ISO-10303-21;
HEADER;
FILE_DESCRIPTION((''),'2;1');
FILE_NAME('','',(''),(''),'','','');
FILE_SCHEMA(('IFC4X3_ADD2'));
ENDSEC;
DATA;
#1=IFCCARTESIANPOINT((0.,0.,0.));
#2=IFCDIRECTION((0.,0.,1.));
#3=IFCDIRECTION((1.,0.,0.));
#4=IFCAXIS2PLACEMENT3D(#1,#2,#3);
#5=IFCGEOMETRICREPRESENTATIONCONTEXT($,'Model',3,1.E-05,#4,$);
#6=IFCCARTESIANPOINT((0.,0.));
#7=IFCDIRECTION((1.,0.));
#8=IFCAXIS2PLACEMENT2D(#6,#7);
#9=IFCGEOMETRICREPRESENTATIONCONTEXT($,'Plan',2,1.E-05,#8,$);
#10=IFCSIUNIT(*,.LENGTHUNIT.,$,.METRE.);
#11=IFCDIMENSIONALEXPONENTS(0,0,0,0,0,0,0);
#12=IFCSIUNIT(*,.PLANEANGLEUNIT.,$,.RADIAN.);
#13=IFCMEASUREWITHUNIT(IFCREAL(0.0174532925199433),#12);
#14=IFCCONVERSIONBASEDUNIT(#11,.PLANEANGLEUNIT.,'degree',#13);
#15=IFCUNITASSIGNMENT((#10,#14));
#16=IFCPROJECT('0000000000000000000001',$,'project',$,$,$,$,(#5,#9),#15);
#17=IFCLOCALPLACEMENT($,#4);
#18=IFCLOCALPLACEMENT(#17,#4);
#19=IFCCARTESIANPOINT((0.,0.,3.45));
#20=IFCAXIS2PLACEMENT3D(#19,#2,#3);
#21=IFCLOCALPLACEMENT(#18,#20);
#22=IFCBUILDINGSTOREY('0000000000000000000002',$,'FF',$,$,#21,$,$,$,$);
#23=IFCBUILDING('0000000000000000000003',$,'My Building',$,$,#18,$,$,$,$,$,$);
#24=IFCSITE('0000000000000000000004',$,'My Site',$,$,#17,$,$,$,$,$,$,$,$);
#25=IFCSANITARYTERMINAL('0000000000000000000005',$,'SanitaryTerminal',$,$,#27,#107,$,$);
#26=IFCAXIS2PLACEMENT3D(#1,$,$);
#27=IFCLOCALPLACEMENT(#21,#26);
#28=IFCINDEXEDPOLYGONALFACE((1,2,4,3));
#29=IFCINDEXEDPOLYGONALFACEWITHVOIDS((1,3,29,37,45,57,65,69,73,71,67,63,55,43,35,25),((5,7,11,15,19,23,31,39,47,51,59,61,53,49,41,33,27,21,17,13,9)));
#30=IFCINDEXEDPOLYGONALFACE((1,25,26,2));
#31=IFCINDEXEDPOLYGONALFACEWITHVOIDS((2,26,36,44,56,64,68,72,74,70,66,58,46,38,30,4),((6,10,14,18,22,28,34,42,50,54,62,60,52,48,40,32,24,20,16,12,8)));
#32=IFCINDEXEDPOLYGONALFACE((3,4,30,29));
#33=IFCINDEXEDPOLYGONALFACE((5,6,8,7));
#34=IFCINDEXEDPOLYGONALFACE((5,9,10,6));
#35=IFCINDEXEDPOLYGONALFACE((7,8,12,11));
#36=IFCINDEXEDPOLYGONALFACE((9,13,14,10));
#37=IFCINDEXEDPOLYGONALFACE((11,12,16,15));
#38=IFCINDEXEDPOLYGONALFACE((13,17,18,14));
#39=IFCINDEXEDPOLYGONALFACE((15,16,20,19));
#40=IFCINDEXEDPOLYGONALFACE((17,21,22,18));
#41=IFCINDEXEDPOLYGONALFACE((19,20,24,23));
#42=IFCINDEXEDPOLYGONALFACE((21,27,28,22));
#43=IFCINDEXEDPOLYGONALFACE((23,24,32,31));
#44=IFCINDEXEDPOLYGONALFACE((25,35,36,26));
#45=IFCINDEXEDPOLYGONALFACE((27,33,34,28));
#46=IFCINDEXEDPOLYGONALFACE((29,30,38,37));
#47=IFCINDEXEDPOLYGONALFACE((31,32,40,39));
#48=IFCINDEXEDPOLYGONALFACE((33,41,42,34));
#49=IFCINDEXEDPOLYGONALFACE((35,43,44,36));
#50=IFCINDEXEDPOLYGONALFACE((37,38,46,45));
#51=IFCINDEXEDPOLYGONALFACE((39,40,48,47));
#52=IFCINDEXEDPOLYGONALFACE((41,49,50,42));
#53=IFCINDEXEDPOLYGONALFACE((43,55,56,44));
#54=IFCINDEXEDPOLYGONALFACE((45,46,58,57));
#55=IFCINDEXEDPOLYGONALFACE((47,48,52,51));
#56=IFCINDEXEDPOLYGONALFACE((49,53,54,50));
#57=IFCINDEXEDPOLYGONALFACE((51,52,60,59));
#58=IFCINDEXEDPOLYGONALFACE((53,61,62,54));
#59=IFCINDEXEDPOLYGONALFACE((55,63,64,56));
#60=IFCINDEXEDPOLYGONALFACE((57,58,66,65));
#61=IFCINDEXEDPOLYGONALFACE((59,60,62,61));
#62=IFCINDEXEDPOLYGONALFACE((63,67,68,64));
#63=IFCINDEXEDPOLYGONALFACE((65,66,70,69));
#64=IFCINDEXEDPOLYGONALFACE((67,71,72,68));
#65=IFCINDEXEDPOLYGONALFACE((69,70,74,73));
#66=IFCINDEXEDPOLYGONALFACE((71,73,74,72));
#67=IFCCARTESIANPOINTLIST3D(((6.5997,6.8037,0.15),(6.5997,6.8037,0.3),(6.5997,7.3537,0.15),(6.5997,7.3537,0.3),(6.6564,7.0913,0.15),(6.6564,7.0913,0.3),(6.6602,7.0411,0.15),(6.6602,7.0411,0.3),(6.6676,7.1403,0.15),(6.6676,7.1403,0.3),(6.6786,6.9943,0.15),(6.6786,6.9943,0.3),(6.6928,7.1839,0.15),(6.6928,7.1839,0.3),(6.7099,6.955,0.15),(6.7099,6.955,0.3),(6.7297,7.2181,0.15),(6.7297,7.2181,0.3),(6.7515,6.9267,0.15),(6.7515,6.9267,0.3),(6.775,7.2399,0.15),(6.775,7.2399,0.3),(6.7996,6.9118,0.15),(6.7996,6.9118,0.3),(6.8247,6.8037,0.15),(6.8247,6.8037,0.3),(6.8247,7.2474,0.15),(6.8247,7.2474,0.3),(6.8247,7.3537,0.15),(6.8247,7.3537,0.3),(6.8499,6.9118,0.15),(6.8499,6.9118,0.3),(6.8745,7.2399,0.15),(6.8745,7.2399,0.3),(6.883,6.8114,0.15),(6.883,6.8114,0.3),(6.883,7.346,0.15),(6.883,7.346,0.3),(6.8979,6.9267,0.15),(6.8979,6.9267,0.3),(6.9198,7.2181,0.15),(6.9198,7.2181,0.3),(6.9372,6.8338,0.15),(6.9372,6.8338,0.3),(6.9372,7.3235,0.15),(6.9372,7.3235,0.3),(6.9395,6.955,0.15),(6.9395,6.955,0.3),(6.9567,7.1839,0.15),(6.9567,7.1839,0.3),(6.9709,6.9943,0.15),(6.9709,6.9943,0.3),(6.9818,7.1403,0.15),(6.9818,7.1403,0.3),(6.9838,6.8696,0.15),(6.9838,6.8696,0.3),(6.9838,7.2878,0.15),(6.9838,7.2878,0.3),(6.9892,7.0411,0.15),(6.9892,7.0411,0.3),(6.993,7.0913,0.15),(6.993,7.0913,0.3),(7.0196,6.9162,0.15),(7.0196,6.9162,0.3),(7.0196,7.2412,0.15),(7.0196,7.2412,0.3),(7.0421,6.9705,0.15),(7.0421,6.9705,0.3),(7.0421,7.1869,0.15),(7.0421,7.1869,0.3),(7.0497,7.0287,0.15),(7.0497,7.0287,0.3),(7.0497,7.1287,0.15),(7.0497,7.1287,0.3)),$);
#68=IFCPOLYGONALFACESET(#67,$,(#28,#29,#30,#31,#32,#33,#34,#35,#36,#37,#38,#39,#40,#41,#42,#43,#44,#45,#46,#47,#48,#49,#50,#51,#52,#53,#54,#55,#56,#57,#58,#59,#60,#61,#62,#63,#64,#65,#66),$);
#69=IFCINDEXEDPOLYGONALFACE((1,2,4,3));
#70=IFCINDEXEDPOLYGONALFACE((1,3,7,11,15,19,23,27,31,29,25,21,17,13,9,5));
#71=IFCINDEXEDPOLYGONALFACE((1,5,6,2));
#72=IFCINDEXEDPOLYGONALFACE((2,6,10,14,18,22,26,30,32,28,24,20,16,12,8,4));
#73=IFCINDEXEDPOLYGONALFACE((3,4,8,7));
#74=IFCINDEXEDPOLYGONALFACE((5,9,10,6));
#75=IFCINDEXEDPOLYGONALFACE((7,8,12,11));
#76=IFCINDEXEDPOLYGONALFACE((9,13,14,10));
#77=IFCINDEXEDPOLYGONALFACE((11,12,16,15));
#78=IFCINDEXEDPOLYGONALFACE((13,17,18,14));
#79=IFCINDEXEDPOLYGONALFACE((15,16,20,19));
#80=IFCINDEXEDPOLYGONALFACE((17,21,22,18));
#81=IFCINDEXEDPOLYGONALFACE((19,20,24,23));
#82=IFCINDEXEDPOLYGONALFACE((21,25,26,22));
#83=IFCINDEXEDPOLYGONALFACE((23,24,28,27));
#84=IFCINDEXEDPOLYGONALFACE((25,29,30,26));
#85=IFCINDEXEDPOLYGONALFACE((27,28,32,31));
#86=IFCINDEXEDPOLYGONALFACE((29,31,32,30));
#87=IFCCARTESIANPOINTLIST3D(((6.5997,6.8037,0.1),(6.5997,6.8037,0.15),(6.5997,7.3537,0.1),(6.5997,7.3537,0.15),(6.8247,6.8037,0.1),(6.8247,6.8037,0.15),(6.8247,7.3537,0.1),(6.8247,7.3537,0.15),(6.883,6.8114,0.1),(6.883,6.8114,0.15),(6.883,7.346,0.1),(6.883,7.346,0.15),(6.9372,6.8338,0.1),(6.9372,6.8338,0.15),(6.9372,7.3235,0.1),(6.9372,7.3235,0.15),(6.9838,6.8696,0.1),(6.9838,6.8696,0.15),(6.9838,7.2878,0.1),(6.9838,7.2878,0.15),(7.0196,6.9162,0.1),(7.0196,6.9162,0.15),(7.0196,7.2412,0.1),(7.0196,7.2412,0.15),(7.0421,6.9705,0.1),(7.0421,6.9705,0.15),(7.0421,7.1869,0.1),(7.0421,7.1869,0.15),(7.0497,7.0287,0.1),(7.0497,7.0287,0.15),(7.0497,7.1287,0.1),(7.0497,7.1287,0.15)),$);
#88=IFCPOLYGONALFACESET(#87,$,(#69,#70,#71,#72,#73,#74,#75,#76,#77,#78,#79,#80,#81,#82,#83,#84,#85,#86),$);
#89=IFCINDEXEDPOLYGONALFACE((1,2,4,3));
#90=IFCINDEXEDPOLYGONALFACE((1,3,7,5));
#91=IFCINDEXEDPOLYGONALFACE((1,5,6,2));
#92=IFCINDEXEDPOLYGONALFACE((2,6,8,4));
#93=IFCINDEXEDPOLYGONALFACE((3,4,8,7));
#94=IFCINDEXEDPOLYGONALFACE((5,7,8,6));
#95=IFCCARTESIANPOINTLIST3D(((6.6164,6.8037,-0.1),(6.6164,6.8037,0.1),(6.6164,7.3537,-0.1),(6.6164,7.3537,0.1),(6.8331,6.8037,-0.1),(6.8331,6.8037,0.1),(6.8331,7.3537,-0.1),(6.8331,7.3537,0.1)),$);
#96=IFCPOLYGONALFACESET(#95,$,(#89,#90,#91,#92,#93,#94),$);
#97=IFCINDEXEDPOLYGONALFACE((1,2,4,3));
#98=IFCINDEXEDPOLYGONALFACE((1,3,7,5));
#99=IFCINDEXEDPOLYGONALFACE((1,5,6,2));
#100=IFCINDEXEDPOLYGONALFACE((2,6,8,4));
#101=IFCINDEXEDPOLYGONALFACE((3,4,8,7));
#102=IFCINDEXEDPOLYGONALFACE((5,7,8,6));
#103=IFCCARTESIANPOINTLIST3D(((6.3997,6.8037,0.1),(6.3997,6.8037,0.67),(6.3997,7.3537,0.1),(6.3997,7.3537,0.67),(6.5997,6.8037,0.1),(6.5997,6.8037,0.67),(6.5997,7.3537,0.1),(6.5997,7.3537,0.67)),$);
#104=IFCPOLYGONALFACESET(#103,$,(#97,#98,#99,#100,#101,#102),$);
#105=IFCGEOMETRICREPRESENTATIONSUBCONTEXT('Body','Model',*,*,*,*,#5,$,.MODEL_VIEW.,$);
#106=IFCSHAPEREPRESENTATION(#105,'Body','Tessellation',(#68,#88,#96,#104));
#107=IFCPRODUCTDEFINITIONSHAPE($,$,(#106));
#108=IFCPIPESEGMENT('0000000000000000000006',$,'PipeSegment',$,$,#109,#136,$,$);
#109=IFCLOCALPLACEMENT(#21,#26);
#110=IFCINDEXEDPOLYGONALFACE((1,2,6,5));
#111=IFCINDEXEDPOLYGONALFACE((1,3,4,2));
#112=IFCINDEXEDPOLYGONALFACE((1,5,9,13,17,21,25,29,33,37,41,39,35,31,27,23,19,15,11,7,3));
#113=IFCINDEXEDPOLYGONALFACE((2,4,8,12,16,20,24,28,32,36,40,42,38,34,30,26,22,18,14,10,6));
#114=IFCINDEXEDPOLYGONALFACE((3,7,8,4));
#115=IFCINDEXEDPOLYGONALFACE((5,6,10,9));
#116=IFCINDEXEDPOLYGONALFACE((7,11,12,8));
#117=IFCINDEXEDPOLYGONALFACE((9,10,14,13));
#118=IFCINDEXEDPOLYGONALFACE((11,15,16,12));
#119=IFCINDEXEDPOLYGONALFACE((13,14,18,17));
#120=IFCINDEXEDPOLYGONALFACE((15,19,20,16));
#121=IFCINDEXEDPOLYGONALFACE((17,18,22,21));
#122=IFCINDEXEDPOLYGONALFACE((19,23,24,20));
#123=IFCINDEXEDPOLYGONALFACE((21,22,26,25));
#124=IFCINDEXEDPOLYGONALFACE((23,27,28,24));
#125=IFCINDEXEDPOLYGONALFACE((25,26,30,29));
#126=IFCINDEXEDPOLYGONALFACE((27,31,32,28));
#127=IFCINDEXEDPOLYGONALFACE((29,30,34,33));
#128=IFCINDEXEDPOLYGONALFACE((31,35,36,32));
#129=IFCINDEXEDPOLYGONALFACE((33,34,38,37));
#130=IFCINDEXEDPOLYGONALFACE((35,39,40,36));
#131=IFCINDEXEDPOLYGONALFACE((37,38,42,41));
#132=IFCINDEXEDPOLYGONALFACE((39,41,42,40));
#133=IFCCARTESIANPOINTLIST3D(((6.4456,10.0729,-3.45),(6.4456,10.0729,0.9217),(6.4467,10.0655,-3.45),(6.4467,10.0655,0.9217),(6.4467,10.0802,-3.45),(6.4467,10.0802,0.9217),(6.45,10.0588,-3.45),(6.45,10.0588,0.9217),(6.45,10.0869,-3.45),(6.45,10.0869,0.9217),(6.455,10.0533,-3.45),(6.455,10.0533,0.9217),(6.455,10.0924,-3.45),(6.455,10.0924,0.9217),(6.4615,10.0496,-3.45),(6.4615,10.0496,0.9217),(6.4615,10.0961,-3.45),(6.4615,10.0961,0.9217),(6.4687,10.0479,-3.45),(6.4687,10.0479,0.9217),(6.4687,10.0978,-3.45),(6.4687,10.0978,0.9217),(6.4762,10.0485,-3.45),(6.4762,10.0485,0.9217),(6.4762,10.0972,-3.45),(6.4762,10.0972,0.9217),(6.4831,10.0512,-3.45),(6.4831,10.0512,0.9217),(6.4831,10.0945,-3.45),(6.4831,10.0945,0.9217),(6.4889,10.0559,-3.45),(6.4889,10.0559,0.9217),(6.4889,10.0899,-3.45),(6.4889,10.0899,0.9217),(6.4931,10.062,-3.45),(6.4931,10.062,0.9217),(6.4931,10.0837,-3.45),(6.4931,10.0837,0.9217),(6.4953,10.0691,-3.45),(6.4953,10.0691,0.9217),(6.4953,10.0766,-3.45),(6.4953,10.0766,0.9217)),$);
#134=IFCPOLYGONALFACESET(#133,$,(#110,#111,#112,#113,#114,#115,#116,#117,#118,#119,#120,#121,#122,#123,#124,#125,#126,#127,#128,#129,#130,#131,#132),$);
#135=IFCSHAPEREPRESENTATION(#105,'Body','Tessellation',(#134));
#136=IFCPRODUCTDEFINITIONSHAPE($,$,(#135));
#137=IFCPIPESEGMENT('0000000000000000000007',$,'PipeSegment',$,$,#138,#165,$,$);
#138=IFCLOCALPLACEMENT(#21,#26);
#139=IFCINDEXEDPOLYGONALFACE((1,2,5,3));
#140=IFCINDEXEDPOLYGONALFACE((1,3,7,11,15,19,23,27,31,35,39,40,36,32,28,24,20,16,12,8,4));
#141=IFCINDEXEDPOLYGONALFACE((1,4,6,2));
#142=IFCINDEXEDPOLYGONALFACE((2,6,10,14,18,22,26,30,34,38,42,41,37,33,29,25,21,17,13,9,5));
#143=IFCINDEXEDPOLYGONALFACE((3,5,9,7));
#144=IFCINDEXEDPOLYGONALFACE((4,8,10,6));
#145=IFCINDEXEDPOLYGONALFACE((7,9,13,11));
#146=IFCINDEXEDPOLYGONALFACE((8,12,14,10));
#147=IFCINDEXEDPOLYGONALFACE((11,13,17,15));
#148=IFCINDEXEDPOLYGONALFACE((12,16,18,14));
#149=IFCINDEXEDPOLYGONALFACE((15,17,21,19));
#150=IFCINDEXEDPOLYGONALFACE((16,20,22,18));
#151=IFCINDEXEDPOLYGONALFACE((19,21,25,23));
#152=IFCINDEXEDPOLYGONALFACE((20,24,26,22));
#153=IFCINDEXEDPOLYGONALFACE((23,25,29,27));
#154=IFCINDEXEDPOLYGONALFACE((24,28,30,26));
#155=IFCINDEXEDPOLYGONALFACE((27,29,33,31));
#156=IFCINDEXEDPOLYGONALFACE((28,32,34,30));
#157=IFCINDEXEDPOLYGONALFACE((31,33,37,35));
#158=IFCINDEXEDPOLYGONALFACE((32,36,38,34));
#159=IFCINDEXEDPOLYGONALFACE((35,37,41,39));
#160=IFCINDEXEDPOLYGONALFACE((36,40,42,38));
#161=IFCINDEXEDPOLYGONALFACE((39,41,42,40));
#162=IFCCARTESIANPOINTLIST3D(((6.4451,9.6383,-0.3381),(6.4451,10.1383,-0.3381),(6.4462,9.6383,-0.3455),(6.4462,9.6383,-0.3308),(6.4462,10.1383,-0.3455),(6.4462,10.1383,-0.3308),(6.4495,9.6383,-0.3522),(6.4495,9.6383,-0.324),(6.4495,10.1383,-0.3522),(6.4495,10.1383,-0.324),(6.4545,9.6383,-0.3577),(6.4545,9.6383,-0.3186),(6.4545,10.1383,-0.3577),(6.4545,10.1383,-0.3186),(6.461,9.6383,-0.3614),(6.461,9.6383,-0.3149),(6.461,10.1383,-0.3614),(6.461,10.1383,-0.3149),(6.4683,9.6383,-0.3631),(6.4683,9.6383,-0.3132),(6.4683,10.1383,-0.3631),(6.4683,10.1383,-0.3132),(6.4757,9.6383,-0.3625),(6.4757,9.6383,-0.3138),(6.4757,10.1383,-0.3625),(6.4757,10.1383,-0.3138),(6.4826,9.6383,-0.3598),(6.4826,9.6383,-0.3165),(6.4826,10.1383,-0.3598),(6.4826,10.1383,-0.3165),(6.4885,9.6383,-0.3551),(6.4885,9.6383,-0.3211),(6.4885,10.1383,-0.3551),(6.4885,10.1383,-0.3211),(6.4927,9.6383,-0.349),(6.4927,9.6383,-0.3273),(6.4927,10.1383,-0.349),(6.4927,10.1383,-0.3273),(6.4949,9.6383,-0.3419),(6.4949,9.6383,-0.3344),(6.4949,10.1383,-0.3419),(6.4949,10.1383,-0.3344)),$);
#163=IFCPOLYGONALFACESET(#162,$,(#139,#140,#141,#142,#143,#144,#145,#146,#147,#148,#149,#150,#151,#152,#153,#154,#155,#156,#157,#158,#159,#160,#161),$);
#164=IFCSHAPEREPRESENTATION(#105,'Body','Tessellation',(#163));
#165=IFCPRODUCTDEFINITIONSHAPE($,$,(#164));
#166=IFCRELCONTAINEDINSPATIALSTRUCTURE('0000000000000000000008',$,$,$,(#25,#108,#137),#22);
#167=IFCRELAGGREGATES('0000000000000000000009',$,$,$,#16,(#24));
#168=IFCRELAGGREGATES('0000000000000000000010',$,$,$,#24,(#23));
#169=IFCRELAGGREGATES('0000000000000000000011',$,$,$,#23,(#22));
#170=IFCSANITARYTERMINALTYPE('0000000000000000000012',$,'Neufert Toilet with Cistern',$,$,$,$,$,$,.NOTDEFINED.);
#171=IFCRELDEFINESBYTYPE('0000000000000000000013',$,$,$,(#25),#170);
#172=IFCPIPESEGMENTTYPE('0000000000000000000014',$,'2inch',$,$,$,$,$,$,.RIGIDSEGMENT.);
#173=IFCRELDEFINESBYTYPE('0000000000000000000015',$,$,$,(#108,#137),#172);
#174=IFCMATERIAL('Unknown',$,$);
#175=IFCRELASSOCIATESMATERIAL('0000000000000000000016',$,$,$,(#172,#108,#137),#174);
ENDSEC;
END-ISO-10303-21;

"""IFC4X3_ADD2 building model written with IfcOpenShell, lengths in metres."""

from ifc_helpers import new_model, entity, si_unit, converted_unit, frame, frame_2d, origin_with_axes, origin_2d_with_axis, place, context, subcontext, project, spatial, line, arc, indexed_curve, circle_curve, circle, outline, extrude, shape, source, transform, mapped, material, material_profile, profile_set, profile_usage, type_object, type_shapes, element, save


model = new_model("IFC4X3_ADD2")

# Units and contexts
model_context = context("Model", 3, precision=1e-05, world=origin_with_axes())
plan_context = context("Plan", 2, precision=1e-05, world=origin_2d_with_axis())
body_context_1 = subcontext(model_context, "Body", "Model", "MODEL_VIEW")
body_context_2 = subcontext(plan_context, "Body", "Plan", "PLAN_VIEW")
ifc_project = project(units=[si_unit("LENGTHUNIT", "METRE"), converted_unit("PLANEANGLEUNIT", "degree", entity("IfcReal", 0.0174532925199433), si_unit("PLANEANGLEUNIT", "RADIAN"), dimensions=[0, 0, 0, 0, 0, 0, 0])], contexts=[model_context, plan_context])

# Site, building, storey
site_placement = place(None, origin_with_axes())
site = spatial("IfcSite", under=ifc_project, at=site_placement, Name="My Site")
building_placement = place(site_placement, origin_with_axes())
building = spatial("IfcBuilding", under=site, at=building_placement, Name="My Building")
storey_placement = place(building_placement, frame((0.0, 0.0, 3.45), z_axis=(0.0, 0.0, 1.0), x_axis=(1.0, 0.0, 0.0)))
storey = spatial("IfcBuildingStorey", under=building, at=storey_placement, Name="FF")

# Shared definitions
ifc_material = material(Name="Unknown")

# Sanitary terminal
sanitary_terminal_type_1 = type_object("IfcSanitaryTerminalType", Name="Neufert Toilet with Cistern", PredefinedType="NOTDEFINED")
shared_shape_1 = source(origin_with_axes(), body_context_1, "Body", "SweptSolid", [
    extrude(outline(indexed_curve([(-0.275, -0.2), (0.275, -0.2), (0.275, -0.425), (0.2091, -0.5841), (0.05, -0.65), (-0.05, -0.65), (-0.2091, -0.5841), (-0.275, -0.425), (0.0, -0.5938), (0.0, -0.2563)], segments=[arc(8, 7, 6), line(6, 5), arc(5, 4, 3), line(3, 2), line(2, 1), line(1, 8)], self_intersect=False), holes=[circle_curve(frame_2d((0.0, -0.425)), 0.1687)]), frame((0.0, 0.0, 0.25), z_axis=(0.0, 0.0, 1.0), x_axis=(1.0, 0.0, 0.0)), (0.0, 0.0, 1.0), 0.15),
    extrude(outline(indexed_curve([(-0.275, -0.2), (0.275, -0.2), (0.275, -0.425), (0.2091, -0.5841), (0.05, -0.65), (-0.05, -0.65), (-0.2091, -0.5841), (-0.275, -0.425)], segments=[line(1, 2), line(2, 3), arc(3, 4, 5), line(5, 6), arc(6, 7, 8), line(8, 1)])), frame((0.0, 0.0, 0.2), z_axis=(0.0, 0.0, 1.0), x_axis=(1.0, 0.0, 0.0)), (0.0, 0.0, 1.0), 0.05),
    extrude(outline(indexed_curve([(-0.275, -0.2167), (0.275, -0.2167), (0.275, -0.4333), (-0.275, -0.4333)], segments=[line(1, 2, 3, 4, 1)])), origin_with_axes(), (0.0, 0.0, 1.0), 0.2),
    extrude(outline(indexed_curve([(-0.275, 0.0), (0.275, 0.0), (0.275, -0.2), (-0.275, -0.2)], segments=[line(1, 2, 3, 4, 1)])), frame((0.0, 0.0, 0.2), z_axis=(0.0, 0.0, 1.0), x_axis=(1.0, 0.0, 0.0)), (0.0, 0.0, 1.0), 0.57),
])
shared_shape_2 = source(origin_with_axes(), body_context_2, "Body", "Curve2D", [
    entity("IfcIndexedPolyCurve", entity("IfcCartesianPointList2D", [[-0.275, 0.0], [0.275, 0.0], [0.275, -0.2], [-0.275, -0.2]]), [entity("IfcLineIndex", [1, 2, 3, 4, 1])]),
    entity("IfcIndexedPolyCurve", entity("IfcCartesianPointList2D", [[0.165, -0.2], [0.1925, -0.335]])),
    entity("IfcTrimmedCurve", entity("IfcEllipse", entity("IfcAxis2Placement2D", entity("IfcCartesianPoint", [0.0, -0.335]), entity("IfcDirection", [1.0, 0.0])), 0.1925, 0.315), [entity("IfcCartesianPoint", [-0.1925, -0.335])], [entity("IfcCartesianPoint", [0.1925, -0.335])], True, "CARTESIAN"),
    entity("IfcIndexedPolyCurve", entity("IfcCartesianPointList2D", [[-0.165, -0.2], [-0.1925, -0.335]])),
    entity("IfcEllipse", entity("IfcAxis2Placement2D", entity("IfcCartesianPoint", [0.0, -0.452]), entity("IfcDirection", [1.0, 0.0])), 0.1313, 0.1575),
    entity("IfcIndexedPolyCurve", entity("IfcCartesianPointList2D", [[-0.0344, -0.452], [-0.0344, -0.4295], [0.0344, -0.4295], [0.0344, -0.452]])),
    entity("IfcTrimmedCurve", entity("IfcEllipse", entity("IfcAxis2Placement2D", entity("IfcCartesianPoint", [0.0, -0.452]), entity("IfcDirection", [1.0, 0.0])), 0.0344, 0.0225), [entity("IfcCartesianPoint", [-0.0344, -0.452])], [entity("IfcCartesianPoint", [0.0344, -0.452])], True, "CARTESIAN"),
])
type_shapes(sanitary_terminal_type_1, [shared_shape_1, shared_shape_2])
sanitary_terminal_1_placement = place(storey_placement, frame((6.3997, 7.0787, -0.1), z_axis=(0.0, 0.0, 1.0), x_axis=(0.0, 1.0, 0.0)))
element("IfcSanitaryTerminal", 1, at=sanitary_terminal_1_placement, inside=storey, type_object=sanitary_terminal_type_1, Name="SanitaryTerminal", shapes=[
    shape(body_context_1, "Body", "MappedRepresentation", [mapped(shared_shape_1, transform((0.0, 0.0, 0.0), x_axis=(1.0, 0.0, 0.0), y_axis=(0.0, 1.0, 0.0), z_axis=(0.0, 0.0, 1.0), scale=1.0))]),
    shape(body_context_2, "Body", "MappedRepresentation", [mapped(shared_shape_2, transform((0.0, 0.0, 0.0), x_axis=(1.0, 0.0, 0.0), y_axis=(0.0, 1.0, 0.0), z_axis=(0.0, 0.0, 1.0), scale=1.0))]),
])

# Pipe segments
ifc_material_profile = material_profile(ifc_material, circle(Radius=0.025))
ifc_profile_set = profile_set([ifc_material_profile])
ifc_profile_usage_1 = profile_usage(ifc_profile_set)
pipe_segment_type = type_object("IfcPipeSegmentType", Name="2inch", PredefinedType="RIGIDSEGMENT", material=ifc_profile_set)
pipe_segment_1_placement = place(storey_placement, frame((6.4706, 10.0729, -3.45), z_axis=(0.0, 0.0, 1.0), x_axis=(-1.0, 0.0, 0.0)))
element("IfcPipeSegment", 2, at=pipe_segment_1_placement, inside=storey, type_object=pipe_segment_type, material=ifc_profile_usage_1, Name="PipeSegment", context=body_context_1, shape_type="SweptSolid", body=[
    extrude(circle(Radius=0.025), origin_with_axes(), (0.0, 0.0, 1.0), 4.3717),
])
ifc_profile_usage_2 = profile_usage(ifc_profile_set)
pipe_segment_2_placement = place(storey_placement, frame((6.4701, 9.6383, -0.3381), z_axis=(0.0, 1.0, 0.0), x_axis=(-1.0, 0.0, 0.0)))
element("IfcPipeSegment", 3, at=pipe_segment_2_placement, inside=storey, type_object=pipe_segment_type, material=ifc_profile_usage_2, Name="PipeSegment", context=body_context_1, shape_type="SweptSolid", body=[
    extrude(circle(Radius=0.025), origin_with_axes(), (0.0, 0.0, 1.0), 0.5),
])

save(model, "model.ifc")
